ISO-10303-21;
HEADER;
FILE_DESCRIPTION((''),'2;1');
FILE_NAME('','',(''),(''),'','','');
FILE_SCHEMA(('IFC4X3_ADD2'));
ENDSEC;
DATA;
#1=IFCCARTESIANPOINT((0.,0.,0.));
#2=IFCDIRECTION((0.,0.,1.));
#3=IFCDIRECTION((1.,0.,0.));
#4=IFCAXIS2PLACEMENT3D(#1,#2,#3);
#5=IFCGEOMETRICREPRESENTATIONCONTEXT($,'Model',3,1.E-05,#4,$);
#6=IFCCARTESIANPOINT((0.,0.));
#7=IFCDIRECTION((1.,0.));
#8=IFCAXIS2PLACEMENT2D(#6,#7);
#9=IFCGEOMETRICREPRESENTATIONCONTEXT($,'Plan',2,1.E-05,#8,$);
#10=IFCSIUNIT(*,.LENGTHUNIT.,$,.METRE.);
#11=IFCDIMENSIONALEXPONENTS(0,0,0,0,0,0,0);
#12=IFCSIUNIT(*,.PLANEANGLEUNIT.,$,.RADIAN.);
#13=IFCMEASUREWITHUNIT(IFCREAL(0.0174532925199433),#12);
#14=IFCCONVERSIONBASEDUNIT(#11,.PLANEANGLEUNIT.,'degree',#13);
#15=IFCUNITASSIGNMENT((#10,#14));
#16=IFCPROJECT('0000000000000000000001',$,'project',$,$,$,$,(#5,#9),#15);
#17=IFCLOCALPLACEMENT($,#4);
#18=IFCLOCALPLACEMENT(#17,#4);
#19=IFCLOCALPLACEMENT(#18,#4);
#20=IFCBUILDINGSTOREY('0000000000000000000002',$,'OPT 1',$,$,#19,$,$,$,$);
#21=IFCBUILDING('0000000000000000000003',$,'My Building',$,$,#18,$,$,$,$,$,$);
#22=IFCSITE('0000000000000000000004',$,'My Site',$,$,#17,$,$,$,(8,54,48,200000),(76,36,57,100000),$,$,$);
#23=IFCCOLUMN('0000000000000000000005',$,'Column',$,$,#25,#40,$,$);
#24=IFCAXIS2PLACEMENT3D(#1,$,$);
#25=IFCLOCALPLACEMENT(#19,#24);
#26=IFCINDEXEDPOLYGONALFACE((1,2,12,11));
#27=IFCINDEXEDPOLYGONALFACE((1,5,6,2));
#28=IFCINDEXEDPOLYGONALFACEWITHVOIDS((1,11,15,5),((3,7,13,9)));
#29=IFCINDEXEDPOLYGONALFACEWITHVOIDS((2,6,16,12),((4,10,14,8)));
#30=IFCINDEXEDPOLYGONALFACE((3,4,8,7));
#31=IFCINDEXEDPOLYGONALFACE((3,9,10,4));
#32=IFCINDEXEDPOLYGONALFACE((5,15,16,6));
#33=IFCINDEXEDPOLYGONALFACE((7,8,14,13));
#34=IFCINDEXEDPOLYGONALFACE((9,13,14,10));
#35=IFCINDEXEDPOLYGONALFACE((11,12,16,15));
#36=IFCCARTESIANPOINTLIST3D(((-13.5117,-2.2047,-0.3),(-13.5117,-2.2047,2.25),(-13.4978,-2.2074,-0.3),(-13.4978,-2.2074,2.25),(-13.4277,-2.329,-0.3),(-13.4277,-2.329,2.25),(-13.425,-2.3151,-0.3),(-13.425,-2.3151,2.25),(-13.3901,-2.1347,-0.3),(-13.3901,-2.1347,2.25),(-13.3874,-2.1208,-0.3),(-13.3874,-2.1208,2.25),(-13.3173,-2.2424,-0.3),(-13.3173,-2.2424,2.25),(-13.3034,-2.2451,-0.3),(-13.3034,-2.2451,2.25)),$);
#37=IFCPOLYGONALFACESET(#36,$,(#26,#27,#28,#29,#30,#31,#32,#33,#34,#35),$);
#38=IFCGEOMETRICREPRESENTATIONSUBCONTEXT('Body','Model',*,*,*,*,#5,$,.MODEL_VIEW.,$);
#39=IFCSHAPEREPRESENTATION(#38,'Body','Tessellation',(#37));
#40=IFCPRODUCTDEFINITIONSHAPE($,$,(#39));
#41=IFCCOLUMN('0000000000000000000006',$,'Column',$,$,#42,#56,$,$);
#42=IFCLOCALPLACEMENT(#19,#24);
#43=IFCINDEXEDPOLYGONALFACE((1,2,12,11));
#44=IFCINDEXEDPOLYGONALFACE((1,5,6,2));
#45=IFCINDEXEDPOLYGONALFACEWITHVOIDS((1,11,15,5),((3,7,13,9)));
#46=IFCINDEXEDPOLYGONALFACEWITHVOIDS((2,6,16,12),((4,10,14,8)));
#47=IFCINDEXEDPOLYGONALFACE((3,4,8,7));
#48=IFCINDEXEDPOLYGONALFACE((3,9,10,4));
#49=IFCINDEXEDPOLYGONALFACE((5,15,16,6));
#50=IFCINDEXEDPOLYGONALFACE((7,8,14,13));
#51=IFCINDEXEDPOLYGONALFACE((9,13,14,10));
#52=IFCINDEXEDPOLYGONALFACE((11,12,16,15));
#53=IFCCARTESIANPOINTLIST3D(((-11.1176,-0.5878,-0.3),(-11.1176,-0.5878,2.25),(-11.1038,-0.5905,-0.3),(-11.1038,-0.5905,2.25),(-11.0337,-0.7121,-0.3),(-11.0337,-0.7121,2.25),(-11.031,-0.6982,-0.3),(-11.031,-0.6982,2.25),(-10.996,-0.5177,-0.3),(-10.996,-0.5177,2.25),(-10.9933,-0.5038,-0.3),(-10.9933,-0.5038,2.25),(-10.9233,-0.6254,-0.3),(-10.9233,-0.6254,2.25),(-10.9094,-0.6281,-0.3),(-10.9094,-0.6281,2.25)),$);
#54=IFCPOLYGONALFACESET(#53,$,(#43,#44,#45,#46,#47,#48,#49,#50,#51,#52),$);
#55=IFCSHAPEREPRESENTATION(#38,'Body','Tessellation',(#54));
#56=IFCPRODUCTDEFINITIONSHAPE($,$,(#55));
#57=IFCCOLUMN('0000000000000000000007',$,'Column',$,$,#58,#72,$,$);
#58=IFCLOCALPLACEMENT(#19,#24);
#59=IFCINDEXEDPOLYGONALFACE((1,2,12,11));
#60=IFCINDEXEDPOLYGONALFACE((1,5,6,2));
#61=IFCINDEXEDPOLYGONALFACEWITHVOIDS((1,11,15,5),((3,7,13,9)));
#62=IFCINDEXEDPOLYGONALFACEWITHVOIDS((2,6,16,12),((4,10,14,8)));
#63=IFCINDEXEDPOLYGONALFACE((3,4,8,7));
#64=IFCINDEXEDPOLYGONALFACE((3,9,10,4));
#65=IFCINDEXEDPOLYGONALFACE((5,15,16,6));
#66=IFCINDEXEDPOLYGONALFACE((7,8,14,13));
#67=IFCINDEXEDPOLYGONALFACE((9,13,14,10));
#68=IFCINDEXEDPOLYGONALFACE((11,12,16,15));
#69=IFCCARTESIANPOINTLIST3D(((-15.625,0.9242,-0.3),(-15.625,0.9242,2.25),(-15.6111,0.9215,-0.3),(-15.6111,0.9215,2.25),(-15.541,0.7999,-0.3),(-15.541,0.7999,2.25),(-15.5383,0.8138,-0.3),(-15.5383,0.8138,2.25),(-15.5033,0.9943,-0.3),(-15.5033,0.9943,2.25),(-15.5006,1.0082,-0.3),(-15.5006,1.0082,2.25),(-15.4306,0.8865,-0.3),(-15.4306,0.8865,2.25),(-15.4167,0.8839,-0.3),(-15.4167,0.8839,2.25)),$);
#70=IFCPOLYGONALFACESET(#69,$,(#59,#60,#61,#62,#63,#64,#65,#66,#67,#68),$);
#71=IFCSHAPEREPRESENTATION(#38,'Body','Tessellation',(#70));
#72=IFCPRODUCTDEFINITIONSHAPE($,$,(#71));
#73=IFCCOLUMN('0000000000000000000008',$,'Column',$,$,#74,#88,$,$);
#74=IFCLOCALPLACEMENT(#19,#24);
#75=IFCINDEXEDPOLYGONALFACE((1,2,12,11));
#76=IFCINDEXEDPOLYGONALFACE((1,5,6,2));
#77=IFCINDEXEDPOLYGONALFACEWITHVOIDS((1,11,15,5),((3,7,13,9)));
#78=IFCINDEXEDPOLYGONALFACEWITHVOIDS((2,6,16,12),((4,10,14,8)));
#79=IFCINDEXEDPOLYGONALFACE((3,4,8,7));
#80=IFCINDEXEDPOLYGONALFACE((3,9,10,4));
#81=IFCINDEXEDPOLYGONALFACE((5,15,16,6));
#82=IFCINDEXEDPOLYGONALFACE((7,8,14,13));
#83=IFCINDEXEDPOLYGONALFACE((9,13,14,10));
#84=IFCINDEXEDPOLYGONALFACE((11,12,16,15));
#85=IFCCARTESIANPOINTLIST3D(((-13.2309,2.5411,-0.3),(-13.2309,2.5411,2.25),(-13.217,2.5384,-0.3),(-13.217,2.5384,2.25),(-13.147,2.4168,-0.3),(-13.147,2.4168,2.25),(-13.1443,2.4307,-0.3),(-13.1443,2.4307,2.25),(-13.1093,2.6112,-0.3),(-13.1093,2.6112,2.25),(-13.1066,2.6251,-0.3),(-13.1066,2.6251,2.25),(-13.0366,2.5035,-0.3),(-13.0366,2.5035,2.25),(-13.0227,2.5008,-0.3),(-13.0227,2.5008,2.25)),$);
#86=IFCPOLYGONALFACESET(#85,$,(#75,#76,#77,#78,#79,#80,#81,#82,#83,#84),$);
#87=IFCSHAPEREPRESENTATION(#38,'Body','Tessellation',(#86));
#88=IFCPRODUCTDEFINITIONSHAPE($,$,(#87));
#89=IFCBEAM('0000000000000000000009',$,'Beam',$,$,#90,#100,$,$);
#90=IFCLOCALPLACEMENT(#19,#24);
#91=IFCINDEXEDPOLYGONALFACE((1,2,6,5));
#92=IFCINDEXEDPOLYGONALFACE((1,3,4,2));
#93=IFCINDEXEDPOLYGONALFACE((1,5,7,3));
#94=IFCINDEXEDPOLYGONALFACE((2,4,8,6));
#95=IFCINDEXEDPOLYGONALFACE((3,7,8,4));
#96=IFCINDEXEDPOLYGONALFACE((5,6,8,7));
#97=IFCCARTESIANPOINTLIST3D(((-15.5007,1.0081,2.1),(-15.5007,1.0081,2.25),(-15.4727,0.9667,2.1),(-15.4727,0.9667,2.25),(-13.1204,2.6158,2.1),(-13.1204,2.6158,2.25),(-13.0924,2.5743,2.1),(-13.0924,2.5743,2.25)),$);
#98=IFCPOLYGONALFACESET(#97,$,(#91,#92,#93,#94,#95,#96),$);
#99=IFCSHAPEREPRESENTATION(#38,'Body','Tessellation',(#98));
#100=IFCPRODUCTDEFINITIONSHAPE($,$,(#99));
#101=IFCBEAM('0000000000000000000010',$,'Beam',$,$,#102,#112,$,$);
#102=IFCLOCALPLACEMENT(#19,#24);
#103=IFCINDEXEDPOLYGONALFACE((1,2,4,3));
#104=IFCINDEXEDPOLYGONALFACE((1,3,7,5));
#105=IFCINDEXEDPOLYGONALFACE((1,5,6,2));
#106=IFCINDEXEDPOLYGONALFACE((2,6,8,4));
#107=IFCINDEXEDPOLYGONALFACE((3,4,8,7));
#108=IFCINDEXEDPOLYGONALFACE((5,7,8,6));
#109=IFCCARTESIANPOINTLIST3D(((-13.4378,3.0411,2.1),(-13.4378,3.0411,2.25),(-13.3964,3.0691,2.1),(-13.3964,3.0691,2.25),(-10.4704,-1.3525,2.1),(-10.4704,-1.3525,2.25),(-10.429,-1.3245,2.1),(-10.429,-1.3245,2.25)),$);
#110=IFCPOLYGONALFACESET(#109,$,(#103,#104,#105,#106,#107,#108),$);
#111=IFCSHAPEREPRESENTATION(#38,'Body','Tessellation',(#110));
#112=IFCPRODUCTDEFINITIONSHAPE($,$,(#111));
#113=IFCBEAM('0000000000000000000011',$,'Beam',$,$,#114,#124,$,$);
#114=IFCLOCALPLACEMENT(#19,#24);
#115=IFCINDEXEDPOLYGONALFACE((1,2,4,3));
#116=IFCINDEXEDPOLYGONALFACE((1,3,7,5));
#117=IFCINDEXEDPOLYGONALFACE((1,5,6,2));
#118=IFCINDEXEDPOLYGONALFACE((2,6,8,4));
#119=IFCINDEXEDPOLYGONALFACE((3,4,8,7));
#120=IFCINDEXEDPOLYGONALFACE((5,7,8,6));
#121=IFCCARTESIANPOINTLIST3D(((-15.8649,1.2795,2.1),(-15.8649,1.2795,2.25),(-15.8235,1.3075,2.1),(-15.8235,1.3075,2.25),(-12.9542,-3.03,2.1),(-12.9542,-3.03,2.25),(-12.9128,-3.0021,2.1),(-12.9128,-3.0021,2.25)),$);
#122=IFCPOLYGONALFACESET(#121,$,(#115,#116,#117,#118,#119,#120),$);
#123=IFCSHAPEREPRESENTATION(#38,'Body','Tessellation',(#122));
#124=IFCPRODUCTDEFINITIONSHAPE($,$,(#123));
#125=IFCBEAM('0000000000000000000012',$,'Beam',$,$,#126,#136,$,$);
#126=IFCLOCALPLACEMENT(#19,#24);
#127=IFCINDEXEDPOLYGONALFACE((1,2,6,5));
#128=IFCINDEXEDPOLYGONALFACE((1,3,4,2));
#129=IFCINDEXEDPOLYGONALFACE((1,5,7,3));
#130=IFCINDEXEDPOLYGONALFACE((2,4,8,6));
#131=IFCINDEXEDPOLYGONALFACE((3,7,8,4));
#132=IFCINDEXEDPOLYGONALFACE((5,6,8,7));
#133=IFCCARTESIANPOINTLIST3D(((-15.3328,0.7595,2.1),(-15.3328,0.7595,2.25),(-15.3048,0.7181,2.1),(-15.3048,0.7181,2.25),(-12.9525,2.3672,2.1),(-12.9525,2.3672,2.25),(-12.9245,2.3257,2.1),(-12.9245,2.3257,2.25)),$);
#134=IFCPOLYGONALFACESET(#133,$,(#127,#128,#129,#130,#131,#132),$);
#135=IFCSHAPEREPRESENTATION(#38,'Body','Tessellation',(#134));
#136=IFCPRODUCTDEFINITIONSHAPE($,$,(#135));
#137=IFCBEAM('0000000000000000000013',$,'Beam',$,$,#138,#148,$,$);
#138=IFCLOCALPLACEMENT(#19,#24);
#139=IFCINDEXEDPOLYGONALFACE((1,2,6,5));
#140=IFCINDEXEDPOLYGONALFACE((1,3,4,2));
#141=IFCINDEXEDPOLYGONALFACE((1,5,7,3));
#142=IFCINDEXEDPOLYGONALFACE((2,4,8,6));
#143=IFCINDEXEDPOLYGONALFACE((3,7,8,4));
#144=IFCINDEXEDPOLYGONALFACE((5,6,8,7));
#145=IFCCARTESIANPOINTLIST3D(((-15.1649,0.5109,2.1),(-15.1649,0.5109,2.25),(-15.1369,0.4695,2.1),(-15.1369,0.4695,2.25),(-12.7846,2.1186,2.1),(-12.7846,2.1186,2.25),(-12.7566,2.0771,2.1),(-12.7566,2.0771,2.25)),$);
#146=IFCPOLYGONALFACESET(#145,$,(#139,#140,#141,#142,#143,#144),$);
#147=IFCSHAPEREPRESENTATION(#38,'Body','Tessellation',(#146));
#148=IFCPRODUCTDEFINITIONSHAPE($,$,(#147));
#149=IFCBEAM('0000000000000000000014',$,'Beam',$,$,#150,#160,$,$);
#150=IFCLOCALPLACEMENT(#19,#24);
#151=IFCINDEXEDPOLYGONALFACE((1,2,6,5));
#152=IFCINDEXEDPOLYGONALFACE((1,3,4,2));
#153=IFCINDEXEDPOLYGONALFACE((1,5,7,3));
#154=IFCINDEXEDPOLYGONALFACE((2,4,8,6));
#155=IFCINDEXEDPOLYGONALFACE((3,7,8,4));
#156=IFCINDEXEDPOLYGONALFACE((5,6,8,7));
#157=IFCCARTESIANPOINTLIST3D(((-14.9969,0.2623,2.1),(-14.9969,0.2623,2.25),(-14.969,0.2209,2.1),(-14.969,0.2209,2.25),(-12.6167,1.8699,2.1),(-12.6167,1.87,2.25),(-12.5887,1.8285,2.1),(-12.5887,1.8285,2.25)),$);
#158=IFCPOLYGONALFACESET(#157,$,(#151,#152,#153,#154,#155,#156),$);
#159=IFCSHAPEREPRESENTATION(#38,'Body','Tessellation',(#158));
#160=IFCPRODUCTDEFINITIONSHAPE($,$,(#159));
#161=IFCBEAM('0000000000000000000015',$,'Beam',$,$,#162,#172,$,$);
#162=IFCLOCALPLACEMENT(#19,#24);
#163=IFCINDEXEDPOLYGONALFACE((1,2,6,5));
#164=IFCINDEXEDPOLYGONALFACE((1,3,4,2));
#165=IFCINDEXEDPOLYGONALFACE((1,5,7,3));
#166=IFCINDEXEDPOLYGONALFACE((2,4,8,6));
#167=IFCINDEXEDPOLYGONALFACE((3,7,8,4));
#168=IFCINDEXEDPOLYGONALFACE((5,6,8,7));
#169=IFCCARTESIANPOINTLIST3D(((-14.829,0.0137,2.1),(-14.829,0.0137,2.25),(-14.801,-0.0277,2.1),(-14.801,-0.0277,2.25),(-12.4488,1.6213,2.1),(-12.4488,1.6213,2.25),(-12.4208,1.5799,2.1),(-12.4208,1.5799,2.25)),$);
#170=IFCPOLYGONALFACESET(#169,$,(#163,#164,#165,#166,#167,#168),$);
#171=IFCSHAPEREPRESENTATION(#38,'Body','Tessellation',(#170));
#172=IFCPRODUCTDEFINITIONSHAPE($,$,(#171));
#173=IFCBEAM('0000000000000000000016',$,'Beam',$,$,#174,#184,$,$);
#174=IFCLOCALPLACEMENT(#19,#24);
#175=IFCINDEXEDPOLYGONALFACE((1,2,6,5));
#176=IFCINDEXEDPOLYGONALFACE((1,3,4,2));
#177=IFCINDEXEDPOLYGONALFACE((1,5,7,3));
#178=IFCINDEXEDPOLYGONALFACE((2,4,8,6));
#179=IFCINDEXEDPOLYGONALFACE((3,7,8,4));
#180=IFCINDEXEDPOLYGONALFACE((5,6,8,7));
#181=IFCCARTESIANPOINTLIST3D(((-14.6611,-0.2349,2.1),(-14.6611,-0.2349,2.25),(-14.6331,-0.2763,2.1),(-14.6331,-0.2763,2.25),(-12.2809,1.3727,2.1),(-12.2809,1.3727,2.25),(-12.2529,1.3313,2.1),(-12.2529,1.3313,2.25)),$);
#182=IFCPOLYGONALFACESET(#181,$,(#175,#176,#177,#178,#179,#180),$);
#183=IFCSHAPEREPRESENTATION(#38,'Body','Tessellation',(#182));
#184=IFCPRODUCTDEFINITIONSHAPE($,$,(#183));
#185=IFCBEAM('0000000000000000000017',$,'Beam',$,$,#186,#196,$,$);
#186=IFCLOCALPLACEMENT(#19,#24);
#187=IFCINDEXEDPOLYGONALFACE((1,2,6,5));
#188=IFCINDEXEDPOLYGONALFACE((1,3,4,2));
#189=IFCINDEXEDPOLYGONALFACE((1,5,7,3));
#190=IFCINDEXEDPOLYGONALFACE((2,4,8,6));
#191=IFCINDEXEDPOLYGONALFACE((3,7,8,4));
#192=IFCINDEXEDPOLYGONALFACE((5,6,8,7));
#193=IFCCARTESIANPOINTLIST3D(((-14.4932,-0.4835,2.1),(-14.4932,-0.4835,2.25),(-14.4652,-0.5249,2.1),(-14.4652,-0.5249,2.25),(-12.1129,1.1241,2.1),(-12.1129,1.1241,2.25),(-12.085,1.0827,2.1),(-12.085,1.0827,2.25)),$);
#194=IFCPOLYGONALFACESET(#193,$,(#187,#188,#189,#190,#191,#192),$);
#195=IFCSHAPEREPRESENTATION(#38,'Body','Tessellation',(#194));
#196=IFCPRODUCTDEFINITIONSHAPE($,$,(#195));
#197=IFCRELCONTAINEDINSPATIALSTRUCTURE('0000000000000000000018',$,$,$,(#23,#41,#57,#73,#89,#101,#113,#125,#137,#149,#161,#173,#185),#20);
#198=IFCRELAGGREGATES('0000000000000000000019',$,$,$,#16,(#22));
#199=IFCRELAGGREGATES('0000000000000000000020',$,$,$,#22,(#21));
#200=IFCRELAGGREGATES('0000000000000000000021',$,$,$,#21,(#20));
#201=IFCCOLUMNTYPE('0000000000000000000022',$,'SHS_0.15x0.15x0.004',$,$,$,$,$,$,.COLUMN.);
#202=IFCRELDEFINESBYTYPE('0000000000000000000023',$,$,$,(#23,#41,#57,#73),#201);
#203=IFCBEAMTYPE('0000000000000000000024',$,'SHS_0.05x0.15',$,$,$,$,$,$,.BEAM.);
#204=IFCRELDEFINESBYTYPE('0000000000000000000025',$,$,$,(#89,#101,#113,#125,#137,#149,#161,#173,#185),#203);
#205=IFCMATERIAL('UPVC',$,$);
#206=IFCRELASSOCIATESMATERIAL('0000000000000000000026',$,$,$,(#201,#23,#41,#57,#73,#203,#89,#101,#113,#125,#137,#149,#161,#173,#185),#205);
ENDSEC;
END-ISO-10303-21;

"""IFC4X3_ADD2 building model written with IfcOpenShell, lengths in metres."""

from ifc_helpers import new_model, entity, si_unit, converted_unit, frame, origin_with_axes, origin_2d_with_axis, place, context, subcontext, project, spatial, rectangle, hollow_rectangle, extrude, material, material_profile, profile_set, profile_usage, type_object, element, save


model = new_model("IFC4X3_ADD2")

# Units and contexts
model_context = context("Model", 3, precision=1e-05, world=origin_with_axes())
plan_context = context("Plan", 2, precision=1e-05, world=origin_2d_with_axis())
body_context = subcontext(model_context, "Body", "Model", "MODEL_VIEW")
ifc_project = project(units=[si_unit("LENGTHUNIT", "METRE"), converted_unit("PLANEANGLEUNIT", "degree", entity("IfcReal", 0.0174532925199433), si_unit("PLANEANGLEUNIT", "RADIAN"), dimensions=[0, 0, 0, 0, 0, 0, 0])], contexts=[model_context, plan_context])

# Site, building, storey
site_placement = place(None, origin_with_axes())
site = spatial("IfcSite", under=ifc_project, at=site_placement, Name="My Site", RefLatitude=(8, 54, 48, 200000), RefLongitude=(76, 36, 57, 100000))
building_placement = place(site_placement, origin_with_axes())
building = spatial("IfcBuilding", under=site, at=building_placement, Name="My Building")
storey_placement = place(building_placement, origin_with_axes())
storey = spatial("IfcBuildingStorey", under=building, at=storey_placement, Name="OPT 1")

# Columns
ifc_material_1 = material(Name="UPVC")
ifc_material_profile_1 = material_profile(ifc_material_1, hollow_rectangle(XDim=0.15, YDim=0.15, WallThickness=0.01))
ifc_profile_set_1 = profile_set([ifc_material_profile_1])
ifc_profile_usage_1 = profile_usage(ifc_profile_set_1, cardinal=5)
column_type = type_object("IfcColumnType", Name="SHS_0.15x0.15x0.004", PredefinedType="COLUMN", material=ifc_profile_set_1)
column_1_placement = place(storey_placement, frame((-13.4075, -2.2249, -0.3), z_axis=(0.0, 0.0, 1.0), x_axis=(0.828694, 0.559703, 0.0)))
element("IfcColumn", 1, at=column_1_placement, inside=storey, type_object=column_type, material=ifc_profile_usage_1, Name="Column", context=body_context, shape_type="SweptSolid", body=[
    extrude(hollow_rectangle(XDim=0.15, YDim=0.15, WallThickness=0.01), origin_with_axes(), (0.0, 0.0, 1.0), 2.55),
])
ifc_profile_usage_2 = profile_usage(ifc_profile_set_1, cardinal=5)
column_2_placement = place(storey_placement, frame((-11.0135, -0.608, -0.3), z_axis=(0.0, 0.0, 1.0), x_axis=(0.828694, 0.559703, 0.0)))
element("IfcColumn", 2, at=column_2_placement, inside=storey, type_object=column_type, material=ifc_profile_usage_2, Name="Column", context=body_context, shape_type="SweptSolid", body=[
    extrude(hollow_rectangle(XDim=0.15, YDim=0.15, WallThickness=0.01), origin_with_axes(), (0.0, 0.0, 1.0), 2.55),
])
ifc_profile_usage_3 = profile_usage(ifc_profile_set_1, cardinal=5)
column_3_placement = place(storey_placement, frame((-15.5208, 0.904, -0.3), z_axis=(0.0, 0.0, 1.0), x_axis=(0.828694, 0.559703, 0.0)))
element("IfcColumn", 3, at=column_3_placement, inside=storey, type_object=column_type, material=ifc_profile_usage_3, Name="Column", context=body_context, shape_type="SweptSolid", body=[
    extrude(hollow_rectangle(XDim=0.15, YDim=0.15, WallThickness=0.01), origin_with_axes(), (0.0, 0.0, 1.0), 2.55),
])
ifc_profile_usage_4 = profile_usage(ifc_profile_set_1, cardinal=5)
column_4_placement = place(storey_placement, frame((-13.1268, 2.521, -0.3), z_axis=(0.0, 0.0, 1.0), x_axis=(0.828694, 0.559703, 0.0)))
element("IfcColumn", 4, at=column_4_placement, inside=storey, type_object=column_type, material=ifc_profile_usage_4, Name="Column", context=body_context, shape_type="SweptSolid", body=[
    extrude(hollow_rectangle(XDim=0.15, YDim=0.15, WallThickness=0.01), origin_with_axes(), (0.0, 0.0, 1.0), 2.55),
])

# Beams
ifc_material_profile_2 = material_profile(ifc_material_1, rectangle(XDim=0.05, YDim=0.15))
ifc_profile_set_2 = profile_set([ifc_material_profile_2])
ifc_profile_usage_5 = profile_usage(ifc_profile_set_2, cardinal=5)
beam_type = type_object("IfcBeamType", Name="SHS_0.05x0.15", PredefinedType="BEAM", material=ifc_profile_set_2)
beam_1_placement = place(storey_placement, frame((-13.1064, 2.5951, 2.175), z_axis=(-0.828693, -0.559703, 0.0), x_axis=(0.559703, -0.828693, 0.0)))
element("IfcBeam", 5, at=beam_1_placement, inside=storey, type_object=beam_type, material=ifc_profile_usage_5, Name="Beam", context=body_context, shape_type="SweptSolid", body=[
    extrude(rectangle(XDim=0.05, YDim=0.15), origin_with_axes(), (0.0, 0.0, 1.0), 2.8723),
])
ifc_profile_usage_6 = profile_usage(ifc_profile_set_2, cardinal=5)
beam_2_placement = place(storey_placement, frame((-10.4497, -1.3385, 2.175), z_axis=(-0.559703, 0.828693, 0.0), x_axis=(-0.828693, -0.559703, 0.0)))
element("IfcBeam", 6, at=beam_2_placement, inside=storey, type_object=beam_type, material=ifc_profile_usage_6, Name="Beam", context=body_context, shape_type="SweptSolid", body=[
    extrude(rectangle(XDim=0.05, YDim=0.15), origin_with_axes(), (0.0, 0.0, 1.0), 5.3018),
])
ifc_profile_usage_7 = profile_usage(ifc_profile_set_2, cardinal=5)
beam_3_placement = place(storey_placement, frame((-12.9335, -3.0161, 2.175), z_axis=(-0.559703, 0.828693, 0.0), x_axis=(-0.828693, -0.559703, 0.0)))
element("IfcBeam", 7, at=beam_3_placement, inside=storey, type_object=beam_type, material=ifc_profile_usage_7, Name="Beam", context=body_context, shape_type="SweptSolid", body=[
    extrude(rectangle(XDim=0.05, YDim=0.15), origin_with_axes(), (0.0, 0.0, 1.0), 5.2004),
])
ifc_profile_usage_8 = profile_usage(ifc_profile_set_2, cardinal=5)
beam_4_placement = place(storey_placement, frame((-12.9385, 2.3464, 2.175), z_axis=(-0.828693, -0.559703, 0.0), x_axis=(0.559703, -0.828693, 0.0)))
element("IfcBeam", 8, at=beam_4_placement, inside=storey, type_object=beam_type, material=ifc_profile_usage_8, Name="Beam", context=body_context, shape_type="SweptSolid", body=[
    extrude(rectangle(XDim=0.05, YDim=0.15), origin_with_axes(), (0.0, 0.0, 1.0), 2.8723),
])
ifc_profile_usage_9 = profile_usage(ifc_profile_set_2, cardinal=5)
beam_5_placement = place(storey_placement, frame((-12.7706, 2.0978, 2.175), z_axis=(-0.828693, -0.559703, 0.0), x_axis=(0.559703, -0.828693, 0.0)))
element("IfcBeam", 9, at=beam_5_placement, inside=storey, type_object=beam_type, material=ifc_profile_usage_9, Name="Beam", context=body_context, shape_type="SweptSolid", body=[
    extrude(rectangle(XDim=0.05, YDim=0.15), origin_with_axes(), (0.0, 0.0, 1.0), 2.8723),
])
ifc_profile_usage_10 = profile_usage(ifc_profile_set_2, cardinal=5)
beam_6_placement = place(storey_placement, frame((-12.6027, 1.8492, 2.175), z_axis=(-0.828693, -0.559703, 0.0), x_axis=(0.559703, -0.828693, 0.0)))
element("IfcBeam", 10, at=beam_6_placement, inside=storey, type_object=beam_type, material=ifc_profile_usage_10, Name="Beam", context=body_context, shape_type="SweptSolid", body=[
    extrude(rectangle(XDim=0.05, YDim=0.15), origin_with_axes(), (0.0, 0.0, 1.0), 2.8723),
])
ifc_profile_usage_11 = profile_usage(ifc_profile_set_2, cardinal=5)
beam_7_placement = place(storey_placement, frame((-12.4348, 1.6006, 2.175), z_axis=(-0.828693, -0.559703, 0.0), x_axis=(0.559703, -0.828693, 0.0)))
element("IfcBeam", 11, at=beam_7_placement, inside=storey, type_object=beam_type, material=ifc_profile_usage_11, Name="Beam", context=body_context, shape_type="SweptSolid", body=[
    extrude(rectangle(XDim=0.05, YDim=0.15), origin_with_axes(), (0.0, 0.0, 1.0), 2.8723),
])
ifc_profile_usage_12 = profile_usage(ifc_profile_set_2, cardinal=5)
beam_8_placement = place(storey_placement, frame((-12.2669, 1.352, 2.175), z_axis=(-0.828693, -0.559703, 0.0), x_axis=(0.559703, -0.828693, 0.0)))
element("IfcBeam", 12, at=beam_8_placement, inside=storey, type_object=beam_type, material=ifc_profile_usage_12, Name="Beam", context=body_context, shape_type="SweptSolid", body=[
    extrude(rectangle(XDim=0.05, YDim=0.15), origin_with_axes(), (0.0, 0.0, 1.0), 2.8723),
])
ifc_profile_usage_13 = profile_usage(ifc_profile_set_2, cardinal=5)
beam_9_placement = place(storey_placement, frame((-12.099, 1.1034, 2.175), z_axis=(-0.828693, -0.559703, 0.0), x_axis=(0.559703, -0.828693, 0.0)))
element("IfcBeam", 13, at=beam_9_placement, inside=storey, type_object=beam_type, material=ifc_profile_usage_13, Name="Beam", context=body_context, shape_type="SweptSolid", body=[
    extrude(rectangle(XDim=0.05, YDim=0.15), origin_with_axes(), (0.0, 0.0, 1.0), 2.8723),
])

save(model, "model.ifc")
